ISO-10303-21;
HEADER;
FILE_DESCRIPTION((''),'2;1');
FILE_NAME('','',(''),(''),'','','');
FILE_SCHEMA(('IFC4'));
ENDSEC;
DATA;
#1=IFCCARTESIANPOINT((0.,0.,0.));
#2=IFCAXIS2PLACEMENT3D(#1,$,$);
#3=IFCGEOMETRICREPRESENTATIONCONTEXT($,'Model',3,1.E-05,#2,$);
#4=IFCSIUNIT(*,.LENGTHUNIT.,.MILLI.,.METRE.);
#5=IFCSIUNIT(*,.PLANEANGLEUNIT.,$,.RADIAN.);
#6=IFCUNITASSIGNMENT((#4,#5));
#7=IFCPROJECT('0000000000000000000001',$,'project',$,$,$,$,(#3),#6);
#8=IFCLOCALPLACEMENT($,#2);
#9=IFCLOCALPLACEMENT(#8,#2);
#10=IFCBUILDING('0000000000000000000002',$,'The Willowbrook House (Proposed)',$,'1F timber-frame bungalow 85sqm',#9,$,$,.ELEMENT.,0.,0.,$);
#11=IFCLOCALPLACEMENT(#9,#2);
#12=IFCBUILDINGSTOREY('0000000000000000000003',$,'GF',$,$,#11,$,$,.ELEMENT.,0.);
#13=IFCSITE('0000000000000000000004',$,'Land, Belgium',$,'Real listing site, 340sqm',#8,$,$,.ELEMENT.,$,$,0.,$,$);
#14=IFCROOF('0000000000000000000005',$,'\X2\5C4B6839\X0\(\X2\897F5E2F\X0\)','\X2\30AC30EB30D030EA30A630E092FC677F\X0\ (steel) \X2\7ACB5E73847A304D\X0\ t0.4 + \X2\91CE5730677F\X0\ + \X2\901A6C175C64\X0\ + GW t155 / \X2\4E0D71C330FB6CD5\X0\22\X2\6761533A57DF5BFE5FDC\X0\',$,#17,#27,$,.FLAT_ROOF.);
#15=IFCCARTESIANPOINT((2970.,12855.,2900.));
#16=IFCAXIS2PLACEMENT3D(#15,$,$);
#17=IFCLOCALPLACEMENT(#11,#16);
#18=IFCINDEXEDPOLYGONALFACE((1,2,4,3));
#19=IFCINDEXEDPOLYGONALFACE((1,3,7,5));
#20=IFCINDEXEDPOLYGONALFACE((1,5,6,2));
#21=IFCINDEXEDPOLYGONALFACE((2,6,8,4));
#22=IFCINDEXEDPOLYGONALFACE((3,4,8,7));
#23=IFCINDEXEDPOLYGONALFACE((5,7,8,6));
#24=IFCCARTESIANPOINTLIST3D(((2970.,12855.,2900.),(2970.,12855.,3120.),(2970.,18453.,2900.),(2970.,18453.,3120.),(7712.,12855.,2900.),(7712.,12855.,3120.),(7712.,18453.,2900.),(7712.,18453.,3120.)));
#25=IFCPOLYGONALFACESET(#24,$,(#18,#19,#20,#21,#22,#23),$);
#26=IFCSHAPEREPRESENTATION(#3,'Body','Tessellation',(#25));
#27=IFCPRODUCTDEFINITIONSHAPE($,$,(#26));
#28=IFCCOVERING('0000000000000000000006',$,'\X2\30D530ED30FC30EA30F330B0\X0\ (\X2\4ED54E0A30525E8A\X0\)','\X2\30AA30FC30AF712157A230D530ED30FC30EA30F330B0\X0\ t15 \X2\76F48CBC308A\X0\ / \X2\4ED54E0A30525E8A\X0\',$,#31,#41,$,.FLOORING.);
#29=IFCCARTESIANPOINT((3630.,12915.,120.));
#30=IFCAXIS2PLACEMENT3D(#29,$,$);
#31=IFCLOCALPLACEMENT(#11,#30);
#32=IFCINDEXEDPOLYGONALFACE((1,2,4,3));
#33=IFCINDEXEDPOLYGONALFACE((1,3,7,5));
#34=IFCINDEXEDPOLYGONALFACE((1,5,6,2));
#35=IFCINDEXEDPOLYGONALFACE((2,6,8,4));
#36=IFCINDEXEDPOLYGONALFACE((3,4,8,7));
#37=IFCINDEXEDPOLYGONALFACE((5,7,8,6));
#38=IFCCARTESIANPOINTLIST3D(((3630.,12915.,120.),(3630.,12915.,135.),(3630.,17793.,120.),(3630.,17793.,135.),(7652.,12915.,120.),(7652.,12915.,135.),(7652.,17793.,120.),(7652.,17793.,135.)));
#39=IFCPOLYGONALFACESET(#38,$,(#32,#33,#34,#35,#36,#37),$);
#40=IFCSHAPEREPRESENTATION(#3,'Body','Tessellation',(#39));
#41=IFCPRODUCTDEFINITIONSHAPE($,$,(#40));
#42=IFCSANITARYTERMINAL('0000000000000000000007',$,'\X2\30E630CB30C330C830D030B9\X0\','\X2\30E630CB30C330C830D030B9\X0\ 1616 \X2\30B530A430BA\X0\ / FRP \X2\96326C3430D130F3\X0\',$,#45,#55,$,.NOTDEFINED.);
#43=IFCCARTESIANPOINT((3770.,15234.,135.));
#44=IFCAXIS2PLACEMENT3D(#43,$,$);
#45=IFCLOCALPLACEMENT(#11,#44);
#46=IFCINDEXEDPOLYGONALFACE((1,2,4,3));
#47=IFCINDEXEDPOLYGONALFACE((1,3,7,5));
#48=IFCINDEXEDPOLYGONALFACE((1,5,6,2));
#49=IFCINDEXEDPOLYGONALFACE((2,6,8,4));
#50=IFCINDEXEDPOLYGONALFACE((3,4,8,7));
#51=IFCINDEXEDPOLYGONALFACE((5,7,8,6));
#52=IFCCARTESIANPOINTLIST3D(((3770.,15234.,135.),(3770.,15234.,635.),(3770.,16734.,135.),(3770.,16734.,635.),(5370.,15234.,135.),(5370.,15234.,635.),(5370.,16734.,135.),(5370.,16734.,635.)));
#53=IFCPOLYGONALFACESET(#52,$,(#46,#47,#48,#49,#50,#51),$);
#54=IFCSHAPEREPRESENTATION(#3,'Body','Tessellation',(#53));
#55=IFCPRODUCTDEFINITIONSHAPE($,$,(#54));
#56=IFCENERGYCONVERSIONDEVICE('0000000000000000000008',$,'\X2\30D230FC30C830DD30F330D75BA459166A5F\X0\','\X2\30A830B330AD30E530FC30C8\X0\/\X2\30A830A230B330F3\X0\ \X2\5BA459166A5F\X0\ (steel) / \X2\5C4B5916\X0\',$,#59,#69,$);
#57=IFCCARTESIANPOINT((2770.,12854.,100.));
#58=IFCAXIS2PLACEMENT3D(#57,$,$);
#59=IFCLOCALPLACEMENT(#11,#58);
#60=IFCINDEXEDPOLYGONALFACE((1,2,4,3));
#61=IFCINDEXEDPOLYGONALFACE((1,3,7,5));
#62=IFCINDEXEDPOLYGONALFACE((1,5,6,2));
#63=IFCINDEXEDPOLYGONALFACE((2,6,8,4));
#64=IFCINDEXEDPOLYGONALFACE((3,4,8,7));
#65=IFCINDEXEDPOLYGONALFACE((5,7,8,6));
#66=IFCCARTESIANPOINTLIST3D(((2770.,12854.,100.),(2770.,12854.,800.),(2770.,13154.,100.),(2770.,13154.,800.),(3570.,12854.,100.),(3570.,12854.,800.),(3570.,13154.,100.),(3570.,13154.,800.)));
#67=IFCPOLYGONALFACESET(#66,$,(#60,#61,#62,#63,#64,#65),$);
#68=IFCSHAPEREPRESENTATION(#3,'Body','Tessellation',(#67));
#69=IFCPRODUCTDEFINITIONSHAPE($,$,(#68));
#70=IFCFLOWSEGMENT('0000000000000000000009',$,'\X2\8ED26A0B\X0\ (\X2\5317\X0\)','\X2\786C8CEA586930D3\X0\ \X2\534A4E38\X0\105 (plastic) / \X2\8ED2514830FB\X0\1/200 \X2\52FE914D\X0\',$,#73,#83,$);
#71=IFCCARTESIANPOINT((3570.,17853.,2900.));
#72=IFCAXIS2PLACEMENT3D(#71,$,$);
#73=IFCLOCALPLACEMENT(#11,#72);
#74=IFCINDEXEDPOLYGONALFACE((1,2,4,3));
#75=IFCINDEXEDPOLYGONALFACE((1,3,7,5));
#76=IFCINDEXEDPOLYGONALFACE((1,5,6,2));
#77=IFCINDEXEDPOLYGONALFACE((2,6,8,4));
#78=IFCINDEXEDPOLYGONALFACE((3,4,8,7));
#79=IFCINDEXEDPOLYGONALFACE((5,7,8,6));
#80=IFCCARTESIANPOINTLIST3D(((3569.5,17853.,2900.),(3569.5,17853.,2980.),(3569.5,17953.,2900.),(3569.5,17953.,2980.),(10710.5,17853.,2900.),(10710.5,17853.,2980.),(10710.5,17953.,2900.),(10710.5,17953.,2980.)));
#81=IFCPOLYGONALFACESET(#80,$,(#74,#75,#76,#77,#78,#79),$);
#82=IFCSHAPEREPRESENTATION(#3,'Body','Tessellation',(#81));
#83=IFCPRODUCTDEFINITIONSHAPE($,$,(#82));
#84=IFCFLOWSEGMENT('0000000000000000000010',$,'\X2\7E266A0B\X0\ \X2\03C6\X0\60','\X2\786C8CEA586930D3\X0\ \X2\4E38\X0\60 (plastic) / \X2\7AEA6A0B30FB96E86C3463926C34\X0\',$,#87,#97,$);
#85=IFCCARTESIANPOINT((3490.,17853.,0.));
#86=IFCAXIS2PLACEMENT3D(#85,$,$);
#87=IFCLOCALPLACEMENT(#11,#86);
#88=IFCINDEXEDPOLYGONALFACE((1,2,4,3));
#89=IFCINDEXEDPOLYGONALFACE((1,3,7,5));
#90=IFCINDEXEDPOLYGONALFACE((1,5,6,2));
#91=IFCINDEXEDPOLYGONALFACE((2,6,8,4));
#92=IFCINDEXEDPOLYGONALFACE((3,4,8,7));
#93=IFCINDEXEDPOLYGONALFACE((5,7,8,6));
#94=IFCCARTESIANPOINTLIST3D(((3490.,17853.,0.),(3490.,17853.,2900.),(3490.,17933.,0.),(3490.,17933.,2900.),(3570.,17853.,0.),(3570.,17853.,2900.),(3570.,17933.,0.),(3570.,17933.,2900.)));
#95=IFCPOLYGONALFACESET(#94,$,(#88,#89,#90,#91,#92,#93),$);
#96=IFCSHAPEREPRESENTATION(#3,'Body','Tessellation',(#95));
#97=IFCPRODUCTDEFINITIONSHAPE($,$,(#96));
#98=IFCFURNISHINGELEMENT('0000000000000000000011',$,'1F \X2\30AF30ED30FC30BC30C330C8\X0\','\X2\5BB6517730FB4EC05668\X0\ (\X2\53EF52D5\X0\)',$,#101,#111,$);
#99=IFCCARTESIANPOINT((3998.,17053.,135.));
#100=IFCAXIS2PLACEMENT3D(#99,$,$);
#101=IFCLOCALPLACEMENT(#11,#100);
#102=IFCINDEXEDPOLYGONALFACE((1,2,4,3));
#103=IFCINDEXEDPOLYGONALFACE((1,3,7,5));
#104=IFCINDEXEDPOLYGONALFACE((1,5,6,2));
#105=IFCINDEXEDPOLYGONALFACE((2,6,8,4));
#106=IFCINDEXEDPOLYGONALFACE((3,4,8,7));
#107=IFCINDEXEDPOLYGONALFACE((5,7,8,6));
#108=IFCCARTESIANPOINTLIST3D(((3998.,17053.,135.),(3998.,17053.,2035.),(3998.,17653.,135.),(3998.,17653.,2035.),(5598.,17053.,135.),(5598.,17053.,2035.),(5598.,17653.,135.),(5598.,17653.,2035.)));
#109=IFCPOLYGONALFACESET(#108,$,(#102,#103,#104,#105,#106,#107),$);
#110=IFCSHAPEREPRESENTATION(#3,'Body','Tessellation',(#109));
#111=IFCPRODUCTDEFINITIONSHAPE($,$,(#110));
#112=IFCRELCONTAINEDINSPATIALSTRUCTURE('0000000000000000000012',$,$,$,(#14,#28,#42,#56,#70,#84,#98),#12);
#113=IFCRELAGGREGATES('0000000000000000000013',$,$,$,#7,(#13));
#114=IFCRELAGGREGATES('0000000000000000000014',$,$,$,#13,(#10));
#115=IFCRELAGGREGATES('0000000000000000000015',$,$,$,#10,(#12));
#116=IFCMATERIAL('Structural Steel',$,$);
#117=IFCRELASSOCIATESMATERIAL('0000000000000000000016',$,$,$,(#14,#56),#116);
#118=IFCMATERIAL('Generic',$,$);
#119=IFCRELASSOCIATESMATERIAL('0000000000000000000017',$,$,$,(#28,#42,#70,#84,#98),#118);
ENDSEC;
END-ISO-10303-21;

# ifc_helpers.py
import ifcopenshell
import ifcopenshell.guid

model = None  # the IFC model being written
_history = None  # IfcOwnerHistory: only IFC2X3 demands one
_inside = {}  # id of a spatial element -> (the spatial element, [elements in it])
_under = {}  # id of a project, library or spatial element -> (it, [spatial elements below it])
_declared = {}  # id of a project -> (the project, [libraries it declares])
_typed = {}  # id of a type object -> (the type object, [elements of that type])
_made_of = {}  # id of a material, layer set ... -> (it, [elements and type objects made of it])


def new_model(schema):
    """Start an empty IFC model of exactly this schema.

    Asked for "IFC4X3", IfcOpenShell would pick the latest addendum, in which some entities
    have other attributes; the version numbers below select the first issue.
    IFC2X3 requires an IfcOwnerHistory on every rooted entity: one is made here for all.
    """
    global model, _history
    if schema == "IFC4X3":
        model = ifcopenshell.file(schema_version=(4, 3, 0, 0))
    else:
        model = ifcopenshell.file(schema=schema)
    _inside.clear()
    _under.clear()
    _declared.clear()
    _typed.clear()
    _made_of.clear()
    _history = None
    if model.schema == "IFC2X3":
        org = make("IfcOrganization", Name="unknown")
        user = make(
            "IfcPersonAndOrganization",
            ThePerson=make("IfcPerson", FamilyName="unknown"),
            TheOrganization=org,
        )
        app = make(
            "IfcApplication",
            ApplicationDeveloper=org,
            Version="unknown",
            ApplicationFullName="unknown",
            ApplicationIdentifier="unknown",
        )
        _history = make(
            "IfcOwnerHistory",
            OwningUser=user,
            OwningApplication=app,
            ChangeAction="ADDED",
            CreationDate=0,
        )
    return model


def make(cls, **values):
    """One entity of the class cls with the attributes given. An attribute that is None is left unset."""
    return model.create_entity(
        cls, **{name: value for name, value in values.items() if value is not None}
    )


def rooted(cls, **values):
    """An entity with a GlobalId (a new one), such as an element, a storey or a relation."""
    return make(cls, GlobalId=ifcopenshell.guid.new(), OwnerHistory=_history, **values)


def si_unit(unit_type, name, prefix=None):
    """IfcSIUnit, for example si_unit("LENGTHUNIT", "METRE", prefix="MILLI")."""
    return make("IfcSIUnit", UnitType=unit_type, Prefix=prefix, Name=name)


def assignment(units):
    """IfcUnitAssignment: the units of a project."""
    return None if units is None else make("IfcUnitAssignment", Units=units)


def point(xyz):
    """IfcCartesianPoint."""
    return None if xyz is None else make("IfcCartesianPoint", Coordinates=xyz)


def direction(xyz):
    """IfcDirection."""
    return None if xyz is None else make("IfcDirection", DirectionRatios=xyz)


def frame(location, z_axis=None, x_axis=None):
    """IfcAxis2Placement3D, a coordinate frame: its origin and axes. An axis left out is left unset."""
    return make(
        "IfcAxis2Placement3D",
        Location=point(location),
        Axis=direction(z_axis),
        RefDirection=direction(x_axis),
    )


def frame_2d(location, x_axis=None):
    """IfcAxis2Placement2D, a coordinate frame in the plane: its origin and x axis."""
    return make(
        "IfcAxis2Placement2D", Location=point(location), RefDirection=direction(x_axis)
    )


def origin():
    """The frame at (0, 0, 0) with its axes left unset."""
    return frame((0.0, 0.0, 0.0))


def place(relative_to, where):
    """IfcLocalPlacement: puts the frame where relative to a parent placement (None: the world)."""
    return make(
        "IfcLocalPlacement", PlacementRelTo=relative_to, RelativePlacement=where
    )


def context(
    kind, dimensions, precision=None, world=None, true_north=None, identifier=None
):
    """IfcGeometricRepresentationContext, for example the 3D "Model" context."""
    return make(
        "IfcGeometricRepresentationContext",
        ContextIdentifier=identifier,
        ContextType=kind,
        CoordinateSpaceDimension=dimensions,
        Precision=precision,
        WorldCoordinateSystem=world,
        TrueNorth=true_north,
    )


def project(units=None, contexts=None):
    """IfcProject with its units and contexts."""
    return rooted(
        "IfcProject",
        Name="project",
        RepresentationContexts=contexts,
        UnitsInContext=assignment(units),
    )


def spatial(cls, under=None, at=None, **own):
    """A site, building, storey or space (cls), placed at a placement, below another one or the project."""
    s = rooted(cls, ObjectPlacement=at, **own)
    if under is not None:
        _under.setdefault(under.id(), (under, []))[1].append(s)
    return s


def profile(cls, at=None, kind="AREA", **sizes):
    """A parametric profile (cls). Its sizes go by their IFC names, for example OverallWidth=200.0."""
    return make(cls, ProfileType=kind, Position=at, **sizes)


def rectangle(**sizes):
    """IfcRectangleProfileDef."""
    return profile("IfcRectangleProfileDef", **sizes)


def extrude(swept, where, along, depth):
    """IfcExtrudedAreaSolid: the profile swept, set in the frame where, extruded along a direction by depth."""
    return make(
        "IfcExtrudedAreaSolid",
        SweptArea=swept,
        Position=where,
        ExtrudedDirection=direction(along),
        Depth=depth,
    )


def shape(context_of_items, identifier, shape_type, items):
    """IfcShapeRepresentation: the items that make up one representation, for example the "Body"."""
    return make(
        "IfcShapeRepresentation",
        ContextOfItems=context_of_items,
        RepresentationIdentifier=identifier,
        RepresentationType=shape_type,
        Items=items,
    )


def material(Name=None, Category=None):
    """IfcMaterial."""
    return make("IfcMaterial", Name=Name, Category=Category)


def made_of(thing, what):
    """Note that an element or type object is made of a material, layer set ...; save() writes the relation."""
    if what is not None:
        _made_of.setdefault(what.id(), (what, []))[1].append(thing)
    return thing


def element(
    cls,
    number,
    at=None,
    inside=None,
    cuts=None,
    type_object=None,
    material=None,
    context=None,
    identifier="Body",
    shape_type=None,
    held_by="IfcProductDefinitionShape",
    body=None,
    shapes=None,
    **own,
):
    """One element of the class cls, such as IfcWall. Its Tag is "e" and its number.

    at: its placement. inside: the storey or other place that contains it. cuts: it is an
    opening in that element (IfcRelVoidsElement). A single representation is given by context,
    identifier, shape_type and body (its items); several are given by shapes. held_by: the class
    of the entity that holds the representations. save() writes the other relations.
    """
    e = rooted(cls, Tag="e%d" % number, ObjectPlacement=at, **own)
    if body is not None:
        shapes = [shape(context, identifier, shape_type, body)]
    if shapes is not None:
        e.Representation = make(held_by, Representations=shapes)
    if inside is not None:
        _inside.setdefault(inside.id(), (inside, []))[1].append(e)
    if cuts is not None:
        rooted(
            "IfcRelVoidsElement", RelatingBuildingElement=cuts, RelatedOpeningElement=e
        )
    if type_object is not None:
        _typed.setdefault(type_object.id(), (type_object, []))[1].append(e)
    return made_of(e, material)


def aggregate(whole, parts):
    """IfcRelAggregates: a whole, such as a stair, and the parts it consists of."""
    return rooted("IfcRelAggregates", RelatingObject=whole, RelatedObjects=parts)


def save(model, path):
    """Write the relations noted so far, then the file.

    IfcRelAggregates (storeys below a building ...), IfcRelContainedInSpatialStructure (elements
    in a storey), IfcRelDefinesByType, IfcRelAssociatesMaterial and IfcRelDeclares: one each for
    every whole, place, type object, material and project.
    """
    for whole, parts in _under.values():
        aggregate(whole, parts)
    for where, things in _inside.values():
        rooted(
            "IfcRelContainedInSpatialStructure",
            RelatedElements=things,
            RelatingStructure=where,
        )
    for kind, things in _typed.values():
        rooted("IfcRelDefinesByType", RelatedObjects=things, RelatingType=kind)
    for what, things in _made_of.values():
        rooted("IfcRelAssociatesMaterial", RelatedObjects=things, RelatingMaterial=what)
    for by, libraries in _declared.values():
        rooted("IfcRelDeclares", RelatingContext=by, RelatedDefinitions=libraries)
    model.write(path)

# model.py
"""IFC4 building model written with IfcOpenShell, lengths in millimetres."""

from ifc_helpers import new_model, si_unit, frame, frame_2d, origin, place, context, project, spatial, rectangle, extrude, material, element, save


model = new_model("IFC4")

# Units and contexts
model_context = context("Model", 3, precision=1e-05, world=origin())
ifc_project = project(units=[si_unit("LENGTHUNIT", "METRE", prefix="MILLI"), si_unit("PLANEANGLEUNIT", "RADIAN")], contexts=[model_context])

# Site, building, storey
site_placement = place(None, origin())
site = spatial("IfcSite", under=ifc_project, at=site_placement, Name="Land, Belgium", ObjectType="Real listing site, 340sqm", CompositionType="ELEMENT", RefElevation=0.0)
building_placement = place(site_placement, origin())
building = spatial("IfcBuilding", under=site, at=building_placement, Name="The Willowbrook House (Proposed)", ObjectType="1F timber-frame bungalow 85sqm", CompositionType="ELEMENT", ElevationOfRefHeight=0.0, ElevationOfTerrain=0.0)
storey_placement = place(building_placement, origin())
storey = spatial("IfcBuildingStorey", under=building, at=storey_placement, Name="GF", CompositionType="ELEMENT", Elevation=0.0)

# Roof
ifc_material_1 = material(Name="Structural Steel")
roof_placement = place(storey_placement, frame((2970.0, 12855.0, 2900.0)))
element("IfcRoof", 1, at=roof_placement, inside=storey, material=ifc_material_1, Name="屋根(西帯)", Description="ガルバリウム鋼板 (steel) 立平葺き t0.4 + 野地板 + 通気層 + GW t155 / 不燃・法22条区域対応", PredefinedType="FLAT_ROOF", context=model_context, shape_type="SweptSolid", body=[
    extrude(rectangle(XDim=4742.0, YDim=5598.0, at=frame_2d((2371.0, 2799.0))), frame((2970.0, 12855.0, 2900.0)), (0.0, 0.0, 1.0), 220.0),
])

# Covering
ifc_material_2 = material(Name="Generic")
covering_placement = place(storey_placement, frame((3630.0, 12915.0, 120.0)))
element("IfcCovering", 2, at=covering_placement, inside=storey, material=ifc_material_2, Name="フローリング (仕上げ床)", Description="オーク無垢フローリング t15 直貼り / 仕上げ床", PredefinedType="FLOORING", context=model_context, shape_type="SweptSolid", body=[
    extrude(rectangle(XDim=4022.0, YDim=4878.0, at=frame_2d((2011.0, 2439.0))), frame((3630.0, 12915.0, 120.0)), (0.0, 0.0, 1.0), 15.0),
])

# Sanitary terminal
sanitary_terminal_placement = place(storey_placement, frame((3770.0, 15234.0, 135.0)))
element("IfcSanitaryTerminal", 3, at=sanitary_terminal_placement, inside=storey, material=ifc_material_2, Name="ユニットバス", Description="ユニットバス 1616 サイズ / FRP 防水パン", PredefinedType="NOTDEFINED", context=model_context, shape_type="SweptSolid", body=[
    extrude(rectangle(XDim=1600.0, YDim=1500.0, at=frame_2d((800.0, 750.0))), frame((3770.0, 15234.0, 135.0)), (0.0, 0.0, 1.0), 500.0),
])

# Energy conversion device
energy_conversion_device_placement = place(storey_placement, frame((2770.0, 12854.0, 100.0)))
element("IfcEnergyConversionDevice", 4, at=energy_conversion_device_placement, inside=storey, material=ifc_material_1, Name="ヒートポンプ室外機", Description="エコキュート/エアコン 室外機 (steel) / 屋外", context=model_context, shape_type="SweptSolid", body=[
    extrude(rectangle(XDim=800.0, YDim=300.0, at=frame_2d((400.0, 150.0))), frame((2770.0, 12854.0, 100.0)), (0.0, 0.0, 1.0), 700.0),
])

# Flow segments
flow_segment_1_placement = place(storey_placement, frame((3570.0, 17853.0, 2900.0)))
element("IfcFlowSegment", 5, at=flow_segment_1_placement, inside=storey, material=ifc_material_2, Name="軒樋 (北)", Description="硬質塩ビ 半丸105 (plastic) / 軒先・1/200 勾配", context=model_context, shape_type="SweptSolid", body=[
    extrude(rectangle(XDim=7141.0, YDim=100.0, at=frame_2d((3570.0, 50.0))), frame((3570.0, 17853.0, 2900.0)), (0.0, 0.0, 1.0), 80.0),
])
flow_segment_2_placement = place(storey_placement, frame((3490.0, 17853.0, 0.0)))
element("IfcFlowSegment", 6, at=flow_segment_2_placement, inside=storey, material=ifc_material_2, Name="縦樋 φ60", Description="硬質塩ビ 丸60 (plastic) / 竪樋・雨水排水", context=model_context, shape_type="SweptSolid", body=[
    extrude(rectangle(XDim=80.0, YDim=80.0, at=frame_2d((40.0, 40.0))), frame((3490.0, 17853.0, 0.0)), (0.0, 0.0, 1.0), 2900.0),
])

# Furnishing element
furnishing_placement = place(storey_placement, frame((3998.0, 17053.0, 135.0)))
element("IfcFurnishingElement", 7, at=furnishing_placement, inside=storey, material=ifc_material_2, Name="1F クローゼット", Description="家具・什器 (可動)", context=model_context, shape_type="SweptSolid", body=[
    extrude(rectangle(XDim=1600.0, YDim=600.0, at=frame_2d((800.0, 300.0))), frame((3998.0, 17053.0, 135.0)), (0.0, 0.0, 1.0), 1900.0),
])

save(model, "model.ifc")
